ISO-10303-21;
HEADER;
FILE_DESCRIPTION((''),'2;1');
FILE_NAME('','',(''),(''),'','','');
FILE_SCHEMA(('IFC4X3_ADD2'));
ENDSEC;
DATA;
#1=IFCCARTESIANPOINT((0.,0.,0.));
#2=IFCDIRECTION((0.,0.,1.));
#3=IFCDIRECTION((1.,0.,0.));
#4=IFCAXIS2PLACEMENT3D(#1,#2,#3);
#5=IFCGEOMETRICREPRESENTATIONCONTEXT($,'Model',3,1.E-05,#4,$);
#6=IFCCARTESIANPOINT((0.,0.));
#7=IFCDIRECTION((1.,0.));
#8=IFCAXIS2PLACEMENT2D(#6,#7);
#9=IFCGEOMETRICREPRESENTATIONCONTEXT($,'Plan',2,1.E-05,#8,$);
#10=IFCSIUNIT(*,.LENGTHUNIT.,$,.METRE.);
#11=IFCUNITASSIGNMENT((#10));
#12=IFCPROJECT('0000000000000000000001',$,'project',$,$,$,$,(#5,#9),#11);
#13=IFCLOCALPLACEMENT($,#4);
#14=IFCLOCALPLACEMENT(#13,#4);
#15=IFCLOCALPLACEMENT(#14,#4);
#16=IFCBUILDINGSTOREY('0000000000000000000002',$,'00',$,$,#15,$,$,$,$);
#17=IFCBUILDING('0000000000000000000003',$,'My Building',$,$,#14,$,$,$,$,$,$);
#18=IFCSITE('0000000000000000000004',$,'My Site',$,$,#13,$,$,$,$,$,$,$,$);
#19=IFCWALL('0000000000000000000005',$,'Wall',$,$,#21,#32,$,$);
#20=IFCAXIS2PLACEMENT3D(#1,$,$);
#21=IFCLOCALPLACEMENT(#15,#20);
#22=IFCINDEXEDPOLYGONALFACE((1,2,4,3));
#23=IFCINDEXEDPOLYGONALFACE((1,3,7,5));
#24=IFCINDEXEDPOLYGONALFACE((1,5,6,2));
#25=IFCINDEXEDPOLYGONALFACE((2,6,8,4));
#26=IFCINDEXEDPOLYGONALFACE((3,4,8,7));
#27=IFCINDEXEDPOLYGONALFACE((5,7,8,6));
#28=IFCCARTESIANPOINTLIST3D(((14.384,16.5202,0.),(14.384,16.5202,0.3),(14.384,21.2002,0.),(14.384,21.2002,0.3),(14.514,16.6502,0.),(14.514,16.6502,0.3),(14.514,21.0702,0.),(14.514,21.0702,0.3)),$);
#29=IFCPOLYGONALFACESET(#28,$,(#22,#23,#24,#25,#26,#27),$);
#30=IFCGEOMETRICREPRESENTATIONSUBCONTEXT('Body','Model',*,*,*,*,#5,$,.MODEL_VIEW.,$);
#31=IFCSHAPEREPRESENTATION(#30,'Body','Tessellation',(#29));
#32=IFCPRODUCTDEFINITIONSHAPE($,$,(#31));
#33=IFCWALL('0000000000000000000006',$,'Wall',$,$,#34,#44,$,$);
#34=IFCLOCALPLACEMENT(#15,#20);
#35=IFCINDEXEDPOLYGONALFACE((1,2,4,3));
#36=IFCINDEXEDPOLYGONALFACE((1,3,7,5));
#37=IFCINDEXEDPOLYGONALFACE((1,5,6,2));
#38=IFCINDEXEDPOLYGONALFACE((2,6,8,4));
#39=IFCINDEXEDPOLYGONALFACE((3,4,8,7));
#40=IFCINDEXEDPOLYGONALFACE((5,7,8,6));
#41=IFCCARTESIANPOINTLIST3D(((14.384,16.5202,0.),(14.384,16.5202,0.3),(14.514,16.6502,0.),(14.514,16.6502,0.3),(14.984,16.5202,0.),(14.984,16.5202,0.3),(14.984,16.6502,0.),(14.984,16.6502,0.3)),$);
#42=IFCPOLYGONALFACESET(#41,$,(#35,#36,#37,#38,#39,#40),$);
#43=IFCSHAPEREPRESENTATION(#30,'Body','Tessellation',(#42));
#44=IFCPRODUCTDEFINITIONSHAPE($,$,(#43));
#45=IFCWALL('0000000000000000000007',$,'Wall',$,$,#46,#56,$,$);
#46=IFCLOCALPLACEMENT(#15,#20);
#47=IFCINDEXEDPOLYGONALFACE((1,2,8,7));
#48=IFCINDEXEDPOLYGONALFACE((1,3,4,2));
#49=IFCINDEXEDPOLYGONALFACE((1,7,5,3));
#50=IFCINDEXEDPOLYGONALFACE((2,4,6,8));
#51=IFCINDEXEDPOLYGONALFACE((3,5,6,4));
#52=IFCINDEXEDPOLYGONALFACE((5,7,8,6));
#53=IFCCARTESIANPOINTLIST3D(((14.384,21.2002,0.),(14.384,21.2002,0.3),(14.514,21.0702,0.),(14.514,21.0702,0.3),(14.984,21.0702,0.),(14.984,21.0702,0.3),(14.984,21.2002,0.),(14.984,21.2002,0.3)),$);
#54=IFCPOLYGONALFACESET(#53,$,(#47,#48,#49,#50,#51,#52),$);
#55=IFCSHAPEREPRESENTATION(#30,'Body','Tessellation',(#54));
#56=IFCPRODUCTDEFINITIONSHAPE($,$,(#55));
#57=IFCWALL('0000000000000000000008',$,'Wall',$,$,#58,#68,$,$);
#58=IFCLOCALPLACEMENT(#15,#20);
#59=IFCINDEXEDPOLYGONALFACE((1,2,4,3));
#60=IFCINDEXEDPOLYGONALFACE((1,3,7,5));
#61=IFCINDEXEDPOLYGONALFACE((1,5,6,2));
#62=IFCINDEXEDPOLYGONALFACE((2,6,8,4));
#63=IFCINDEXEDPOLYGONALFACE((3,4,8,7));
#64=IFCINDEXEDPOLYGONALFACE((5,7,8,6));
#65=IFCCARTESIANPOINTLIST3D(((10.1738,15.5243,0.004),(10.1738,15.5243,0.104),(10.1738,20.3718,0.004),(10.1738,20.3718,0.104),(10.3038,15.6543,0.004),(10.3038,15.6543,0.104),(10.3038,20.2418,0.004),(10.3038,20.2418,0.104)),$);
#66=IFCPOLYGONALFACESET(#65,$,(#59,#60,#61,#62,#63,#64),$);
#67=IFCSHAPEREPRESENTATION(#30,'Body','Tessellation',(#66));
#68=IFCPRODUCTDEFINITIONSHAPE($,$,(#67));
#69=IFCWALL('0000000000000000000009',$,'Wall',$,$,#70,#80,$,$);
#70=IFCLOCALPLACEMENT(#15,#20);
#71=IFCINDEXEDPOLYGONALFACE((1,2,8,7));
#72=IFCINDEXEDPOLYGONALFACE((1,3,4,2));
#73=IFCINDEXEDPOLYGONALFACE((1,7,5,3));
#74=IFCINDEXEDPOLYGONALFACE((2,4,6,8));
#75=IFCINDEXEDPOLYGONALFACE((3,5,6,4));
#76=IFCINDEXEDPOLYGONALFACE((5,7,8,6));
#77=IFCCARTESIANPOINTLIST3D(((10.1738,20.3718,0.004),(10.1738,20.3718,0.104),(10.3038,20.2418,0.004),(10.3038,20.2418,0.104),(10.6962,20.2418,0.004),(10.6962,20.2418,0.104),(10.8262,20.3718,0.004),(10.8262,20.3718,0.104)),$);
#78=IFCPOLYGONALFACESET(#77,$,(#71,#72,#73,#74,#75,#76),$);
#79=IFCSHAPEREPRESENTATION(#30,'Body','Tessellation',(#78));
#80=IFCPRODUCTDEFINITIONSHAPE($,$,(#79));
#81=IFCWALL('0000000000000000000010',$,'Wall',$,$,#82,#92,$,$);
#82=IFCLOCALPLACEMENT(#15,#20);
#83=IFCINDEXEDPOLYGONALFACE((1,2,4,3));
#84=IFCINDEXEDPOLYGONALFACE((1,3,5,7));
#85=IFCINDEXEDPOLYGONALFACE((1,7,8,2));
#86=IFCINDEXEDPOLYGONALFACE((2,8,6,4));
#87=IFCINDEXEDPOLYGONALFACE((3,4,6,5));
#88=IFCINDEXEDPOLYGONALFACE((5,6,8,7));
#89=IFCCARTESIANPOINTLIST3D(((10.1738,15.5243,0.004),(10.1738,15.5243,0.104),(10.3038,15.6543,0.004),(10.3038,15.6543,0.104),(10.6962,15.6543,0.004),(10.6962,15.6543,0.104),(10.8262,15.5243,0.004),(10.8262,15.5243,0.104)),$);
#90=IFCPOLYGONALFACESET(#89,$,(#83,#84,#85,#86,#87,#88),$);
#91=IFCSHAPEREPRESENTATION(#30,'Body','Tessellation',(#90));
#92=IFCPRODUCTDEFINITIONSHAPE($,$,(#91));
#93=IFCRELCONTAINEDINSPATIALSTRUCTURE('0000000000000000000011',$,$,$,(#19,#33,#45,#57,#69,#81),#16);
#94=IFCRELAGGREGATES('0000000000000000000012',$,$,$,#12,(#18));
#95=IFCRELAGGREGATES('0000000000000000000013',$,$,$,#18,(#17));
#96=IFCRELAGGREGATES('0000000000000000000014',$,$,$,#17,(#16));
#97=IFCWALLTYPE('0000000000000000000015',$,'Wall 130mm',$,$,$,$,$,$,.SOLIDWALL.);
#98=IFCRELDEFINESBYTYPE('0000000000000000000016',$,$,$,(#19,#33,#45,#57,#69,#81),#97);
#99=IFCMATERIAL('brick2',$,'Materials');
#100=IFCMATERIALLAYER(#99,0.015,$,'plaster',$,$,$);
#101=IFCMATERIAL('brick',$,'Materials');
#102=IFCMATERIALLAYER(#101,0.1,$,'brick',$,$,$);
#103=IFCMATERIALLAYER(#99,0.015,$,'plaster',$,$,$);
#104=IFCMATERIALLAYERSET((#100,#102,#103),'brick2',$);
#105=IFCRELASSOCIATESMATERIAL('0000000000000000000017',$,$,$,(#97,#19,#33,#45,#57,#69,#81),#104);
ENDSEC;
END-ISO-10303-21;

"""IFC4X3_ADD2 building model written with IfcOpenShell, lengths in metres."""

from ifc_helpers import new_model, si_unit, frame, origin_with_axes, origin_2d_with_axis, place, context, subcontext, project, spatial, line, indexed_curve, outline, extrude, material, layer, layer_set, layer_usage, type_object, element, save


model = new_model("IFC4X3_ADD2")

# Units and contexts
model_context = context("Model", 3, precision=1e-05, world=origin_with_axes())
plan_context = context("Plan", 2, precision=1e-05, world=origin_2d_with_axis())
body_context_1 = subcontext(model_context, "Body", "Model", "MODEL_VIEW")
ifc_project = project(units=[si_unit("LENGTHUNIT", "METRE")], contexts=[model_context, plan_context])

# Site, building, storey
site_placement = place(None, origin_with_axes())
site = spatial("IfcSite", under=ifc_project, at=site_placement, Name="My Site")
building_placement = place(site_placement, origin_with_axes())
building = spatial("IfcBuilding", under=site, at=building_placement, Name="My Building")
storey_placement = place(building_placement, origin_with_axes())
storey = spatial("IfcBuildingStorey", under=building, at=storey_placement, Name="00")

# Walls
ifc_material_1 = material(Name="brick2", Category="Materials")
ifc_layer_1 = layer(ifc_material_1, 0.015, Name="plaster")
ifc_material_2 = material(Name="brick", Category="Materials")
ifc_layer_2 = layer(ifc_material_2, 0.1, Name="brick")
ifc_layer_3 = layer(ifc_material_1, 0.015, Name="plaster")
ifc_layer_set_1 = layer_set([ifc_layer_1, ifc_layer_2, ifc_layer_3], Name="brick2")
wall_type_1 = type_object("IfcWallType", Name="Wall 130mm", PredefinedType="SOLIDWALL", material=ifc_layer_set_1)
ifc_layer_usage_1 = layer_usage(ifc_layer_set_1, "AXIS2", "POSITIVE", 0.0)
wall_1_placement = place(storey_placement, frame((14.514, 16.5202, 0.0), z_axis=(0.0, 0.0, 1.0), x_axis=(0.0, 1.0, 0.0)))
element("IfcWall", 1, at=wall_1_placement, inside=storey, type_object=wall_type_1, material=ifc_layer_usage_1, Name="Wall", context=body_context_1, shape_type="SweptSolid", body=[
    extrude(outline(indexed_curve([(0.13, 0.0), (0.0, 0.13), (4.68, 0.13), (4.55, 0.0)], segments=[line(1, 2, 3, 4, 1)])), origin_with_axes(), (0.0, 0.0, 1.0), 0.3),
])
ifc_layer_usage_2 = layer_usage(ifc_layer_set_1, "AXIS2", "POSITIVE", 0.0)
wall_2_placement = place(storey_placement, frame((14.514, 16.5202, 0.0), z_axis=(0.0, 0.0, 1.0), x_axis=(1.0, 0.0, 0.0)))
element("IfcWall", 2, at=wall_2_placement, inside=storey, type_object=wall_type_1, material=ifc_layer_usage_2, Name="Wall", context=body_context_1, shape_type="SweptSolid", body=[
    extrude(outline(indexed_curve([(-0.13, 0.0), (0.0, 0.13), (0.47, 0.13), (0.47, 0.0)], segments=[line(1, 2, 3, 4, 1)])), origin_with_axes(), (0.0, 0.0, 1.0), 0.3),
])
ifc_layer_usage_3 = layer_usage(ifc_layer_set_1, "AXIS2", "POSITIVE", 0.0)
wall_3_placement = place(storey_placement, frame((14.514, 21.0702, 0.0), z_axis=(0.0, 0.0, 1.0), x_axis=(1.0, 0.0, 0.0)))
element("IfcWall", 3, at=wall_3_placement, inside=storey, type_object=wall_type_1, material=ifc_layer_usage_3, Name="Wall", context=body_context_1, shape_type="SweptSolid", body=[
    extrude(outline(indexed_curve([(0.0, 0.0), (-0.13, 0.13), (0.47, 0.13), (0.47, 0.0)], segments=[line(1, 2, 3, 4, 1)])), origin_with_axes(), (0.0, 0.0, 1.0), 0.3),
])
ifc_layer_usage_4 = layer_usage(ifc_layer_set_1, "AXIS2", "POSITIVE", 0.0)
wall_4_placement = place(storey_placement, frame((10.3038, 15.6543, 0.004), z_axis=(0.0, 0.0, 1.0), x_axis=(0.000001, 1.0, 0.0)))
element("IfcWall", 4, at=wall_4_placement, inside=storey, type_object=wall_type_1, material=ifc_layer_usage_4, Name="Wall", context=body_context_1, shape_type="SweptSolid", body=[
    extrude(outline(indexed_curve([(0.0, 0.0), (-0.13, 0.13), (4.7175, 0.13), (4.5875, 0.0)], segments=[line(1, 2, 3, 4, 1)])), origin_with_axes(), (0.0, 0.0, 1.0), 0.1),
])
ifc_layer_usage_5 = layer_usage(ifc_layer_set_1, "AXIS2", "POSITIVE", 0.0)
wall_5_placement = place(storey_placement, frame((10.8262, 20.3718, 0.004), z_axis=(0.0, 0.0, 1.0), x_axis=(-1.0, 0.000001, 0.0)))
element("IfcWall", 5, at=wall_5_placement, inside=storey, type_object=wall_type_1, material=ifc_layer_usage_5, Name="Wall", context=body_context_1, shape_type="SweptSolid", body=[
    extrude(outline(indexed_curve([(0.0, 0.0), (0.13, 0.13), (0.5224, 0.13), (0.6524, 0.0)], segments=[line(1, 2, 3, 4, 1)])), origin_with_axes(), (0.0, 0.0, 1.0), 0.1),
])
ifc_layer_usage_6 = layer_usage(ifc_layer_set_1, "AXIS2", "POSITIVE", 0.0)
wall_6_placement = place(storey_placement, frame((10.8262, 15.6543, 0.004), z_axis=(0.0, 0.0, 1.0), x_axis=(-1.0, 0.000001, 0.0)))
element("IfcWall", 6, at=wall_6_placement, inside=storey, type_object=wall_type_1, material=ifc_layer_usage_6, Name="Wall", context=body_context_1, shape_type="SweptSolid", body=[
    extrude(outline(indexed_curve([(0.13, 0.0), (0.0, 0.13), (0.6524, 0.13), (0.5224, 0.0)], segments=[line(1, 2, 3, 4, 1)])), origin_with_axes(), (0.0, 0.0, 1.0), 0.1),
])

save(model, "model.ifc")
